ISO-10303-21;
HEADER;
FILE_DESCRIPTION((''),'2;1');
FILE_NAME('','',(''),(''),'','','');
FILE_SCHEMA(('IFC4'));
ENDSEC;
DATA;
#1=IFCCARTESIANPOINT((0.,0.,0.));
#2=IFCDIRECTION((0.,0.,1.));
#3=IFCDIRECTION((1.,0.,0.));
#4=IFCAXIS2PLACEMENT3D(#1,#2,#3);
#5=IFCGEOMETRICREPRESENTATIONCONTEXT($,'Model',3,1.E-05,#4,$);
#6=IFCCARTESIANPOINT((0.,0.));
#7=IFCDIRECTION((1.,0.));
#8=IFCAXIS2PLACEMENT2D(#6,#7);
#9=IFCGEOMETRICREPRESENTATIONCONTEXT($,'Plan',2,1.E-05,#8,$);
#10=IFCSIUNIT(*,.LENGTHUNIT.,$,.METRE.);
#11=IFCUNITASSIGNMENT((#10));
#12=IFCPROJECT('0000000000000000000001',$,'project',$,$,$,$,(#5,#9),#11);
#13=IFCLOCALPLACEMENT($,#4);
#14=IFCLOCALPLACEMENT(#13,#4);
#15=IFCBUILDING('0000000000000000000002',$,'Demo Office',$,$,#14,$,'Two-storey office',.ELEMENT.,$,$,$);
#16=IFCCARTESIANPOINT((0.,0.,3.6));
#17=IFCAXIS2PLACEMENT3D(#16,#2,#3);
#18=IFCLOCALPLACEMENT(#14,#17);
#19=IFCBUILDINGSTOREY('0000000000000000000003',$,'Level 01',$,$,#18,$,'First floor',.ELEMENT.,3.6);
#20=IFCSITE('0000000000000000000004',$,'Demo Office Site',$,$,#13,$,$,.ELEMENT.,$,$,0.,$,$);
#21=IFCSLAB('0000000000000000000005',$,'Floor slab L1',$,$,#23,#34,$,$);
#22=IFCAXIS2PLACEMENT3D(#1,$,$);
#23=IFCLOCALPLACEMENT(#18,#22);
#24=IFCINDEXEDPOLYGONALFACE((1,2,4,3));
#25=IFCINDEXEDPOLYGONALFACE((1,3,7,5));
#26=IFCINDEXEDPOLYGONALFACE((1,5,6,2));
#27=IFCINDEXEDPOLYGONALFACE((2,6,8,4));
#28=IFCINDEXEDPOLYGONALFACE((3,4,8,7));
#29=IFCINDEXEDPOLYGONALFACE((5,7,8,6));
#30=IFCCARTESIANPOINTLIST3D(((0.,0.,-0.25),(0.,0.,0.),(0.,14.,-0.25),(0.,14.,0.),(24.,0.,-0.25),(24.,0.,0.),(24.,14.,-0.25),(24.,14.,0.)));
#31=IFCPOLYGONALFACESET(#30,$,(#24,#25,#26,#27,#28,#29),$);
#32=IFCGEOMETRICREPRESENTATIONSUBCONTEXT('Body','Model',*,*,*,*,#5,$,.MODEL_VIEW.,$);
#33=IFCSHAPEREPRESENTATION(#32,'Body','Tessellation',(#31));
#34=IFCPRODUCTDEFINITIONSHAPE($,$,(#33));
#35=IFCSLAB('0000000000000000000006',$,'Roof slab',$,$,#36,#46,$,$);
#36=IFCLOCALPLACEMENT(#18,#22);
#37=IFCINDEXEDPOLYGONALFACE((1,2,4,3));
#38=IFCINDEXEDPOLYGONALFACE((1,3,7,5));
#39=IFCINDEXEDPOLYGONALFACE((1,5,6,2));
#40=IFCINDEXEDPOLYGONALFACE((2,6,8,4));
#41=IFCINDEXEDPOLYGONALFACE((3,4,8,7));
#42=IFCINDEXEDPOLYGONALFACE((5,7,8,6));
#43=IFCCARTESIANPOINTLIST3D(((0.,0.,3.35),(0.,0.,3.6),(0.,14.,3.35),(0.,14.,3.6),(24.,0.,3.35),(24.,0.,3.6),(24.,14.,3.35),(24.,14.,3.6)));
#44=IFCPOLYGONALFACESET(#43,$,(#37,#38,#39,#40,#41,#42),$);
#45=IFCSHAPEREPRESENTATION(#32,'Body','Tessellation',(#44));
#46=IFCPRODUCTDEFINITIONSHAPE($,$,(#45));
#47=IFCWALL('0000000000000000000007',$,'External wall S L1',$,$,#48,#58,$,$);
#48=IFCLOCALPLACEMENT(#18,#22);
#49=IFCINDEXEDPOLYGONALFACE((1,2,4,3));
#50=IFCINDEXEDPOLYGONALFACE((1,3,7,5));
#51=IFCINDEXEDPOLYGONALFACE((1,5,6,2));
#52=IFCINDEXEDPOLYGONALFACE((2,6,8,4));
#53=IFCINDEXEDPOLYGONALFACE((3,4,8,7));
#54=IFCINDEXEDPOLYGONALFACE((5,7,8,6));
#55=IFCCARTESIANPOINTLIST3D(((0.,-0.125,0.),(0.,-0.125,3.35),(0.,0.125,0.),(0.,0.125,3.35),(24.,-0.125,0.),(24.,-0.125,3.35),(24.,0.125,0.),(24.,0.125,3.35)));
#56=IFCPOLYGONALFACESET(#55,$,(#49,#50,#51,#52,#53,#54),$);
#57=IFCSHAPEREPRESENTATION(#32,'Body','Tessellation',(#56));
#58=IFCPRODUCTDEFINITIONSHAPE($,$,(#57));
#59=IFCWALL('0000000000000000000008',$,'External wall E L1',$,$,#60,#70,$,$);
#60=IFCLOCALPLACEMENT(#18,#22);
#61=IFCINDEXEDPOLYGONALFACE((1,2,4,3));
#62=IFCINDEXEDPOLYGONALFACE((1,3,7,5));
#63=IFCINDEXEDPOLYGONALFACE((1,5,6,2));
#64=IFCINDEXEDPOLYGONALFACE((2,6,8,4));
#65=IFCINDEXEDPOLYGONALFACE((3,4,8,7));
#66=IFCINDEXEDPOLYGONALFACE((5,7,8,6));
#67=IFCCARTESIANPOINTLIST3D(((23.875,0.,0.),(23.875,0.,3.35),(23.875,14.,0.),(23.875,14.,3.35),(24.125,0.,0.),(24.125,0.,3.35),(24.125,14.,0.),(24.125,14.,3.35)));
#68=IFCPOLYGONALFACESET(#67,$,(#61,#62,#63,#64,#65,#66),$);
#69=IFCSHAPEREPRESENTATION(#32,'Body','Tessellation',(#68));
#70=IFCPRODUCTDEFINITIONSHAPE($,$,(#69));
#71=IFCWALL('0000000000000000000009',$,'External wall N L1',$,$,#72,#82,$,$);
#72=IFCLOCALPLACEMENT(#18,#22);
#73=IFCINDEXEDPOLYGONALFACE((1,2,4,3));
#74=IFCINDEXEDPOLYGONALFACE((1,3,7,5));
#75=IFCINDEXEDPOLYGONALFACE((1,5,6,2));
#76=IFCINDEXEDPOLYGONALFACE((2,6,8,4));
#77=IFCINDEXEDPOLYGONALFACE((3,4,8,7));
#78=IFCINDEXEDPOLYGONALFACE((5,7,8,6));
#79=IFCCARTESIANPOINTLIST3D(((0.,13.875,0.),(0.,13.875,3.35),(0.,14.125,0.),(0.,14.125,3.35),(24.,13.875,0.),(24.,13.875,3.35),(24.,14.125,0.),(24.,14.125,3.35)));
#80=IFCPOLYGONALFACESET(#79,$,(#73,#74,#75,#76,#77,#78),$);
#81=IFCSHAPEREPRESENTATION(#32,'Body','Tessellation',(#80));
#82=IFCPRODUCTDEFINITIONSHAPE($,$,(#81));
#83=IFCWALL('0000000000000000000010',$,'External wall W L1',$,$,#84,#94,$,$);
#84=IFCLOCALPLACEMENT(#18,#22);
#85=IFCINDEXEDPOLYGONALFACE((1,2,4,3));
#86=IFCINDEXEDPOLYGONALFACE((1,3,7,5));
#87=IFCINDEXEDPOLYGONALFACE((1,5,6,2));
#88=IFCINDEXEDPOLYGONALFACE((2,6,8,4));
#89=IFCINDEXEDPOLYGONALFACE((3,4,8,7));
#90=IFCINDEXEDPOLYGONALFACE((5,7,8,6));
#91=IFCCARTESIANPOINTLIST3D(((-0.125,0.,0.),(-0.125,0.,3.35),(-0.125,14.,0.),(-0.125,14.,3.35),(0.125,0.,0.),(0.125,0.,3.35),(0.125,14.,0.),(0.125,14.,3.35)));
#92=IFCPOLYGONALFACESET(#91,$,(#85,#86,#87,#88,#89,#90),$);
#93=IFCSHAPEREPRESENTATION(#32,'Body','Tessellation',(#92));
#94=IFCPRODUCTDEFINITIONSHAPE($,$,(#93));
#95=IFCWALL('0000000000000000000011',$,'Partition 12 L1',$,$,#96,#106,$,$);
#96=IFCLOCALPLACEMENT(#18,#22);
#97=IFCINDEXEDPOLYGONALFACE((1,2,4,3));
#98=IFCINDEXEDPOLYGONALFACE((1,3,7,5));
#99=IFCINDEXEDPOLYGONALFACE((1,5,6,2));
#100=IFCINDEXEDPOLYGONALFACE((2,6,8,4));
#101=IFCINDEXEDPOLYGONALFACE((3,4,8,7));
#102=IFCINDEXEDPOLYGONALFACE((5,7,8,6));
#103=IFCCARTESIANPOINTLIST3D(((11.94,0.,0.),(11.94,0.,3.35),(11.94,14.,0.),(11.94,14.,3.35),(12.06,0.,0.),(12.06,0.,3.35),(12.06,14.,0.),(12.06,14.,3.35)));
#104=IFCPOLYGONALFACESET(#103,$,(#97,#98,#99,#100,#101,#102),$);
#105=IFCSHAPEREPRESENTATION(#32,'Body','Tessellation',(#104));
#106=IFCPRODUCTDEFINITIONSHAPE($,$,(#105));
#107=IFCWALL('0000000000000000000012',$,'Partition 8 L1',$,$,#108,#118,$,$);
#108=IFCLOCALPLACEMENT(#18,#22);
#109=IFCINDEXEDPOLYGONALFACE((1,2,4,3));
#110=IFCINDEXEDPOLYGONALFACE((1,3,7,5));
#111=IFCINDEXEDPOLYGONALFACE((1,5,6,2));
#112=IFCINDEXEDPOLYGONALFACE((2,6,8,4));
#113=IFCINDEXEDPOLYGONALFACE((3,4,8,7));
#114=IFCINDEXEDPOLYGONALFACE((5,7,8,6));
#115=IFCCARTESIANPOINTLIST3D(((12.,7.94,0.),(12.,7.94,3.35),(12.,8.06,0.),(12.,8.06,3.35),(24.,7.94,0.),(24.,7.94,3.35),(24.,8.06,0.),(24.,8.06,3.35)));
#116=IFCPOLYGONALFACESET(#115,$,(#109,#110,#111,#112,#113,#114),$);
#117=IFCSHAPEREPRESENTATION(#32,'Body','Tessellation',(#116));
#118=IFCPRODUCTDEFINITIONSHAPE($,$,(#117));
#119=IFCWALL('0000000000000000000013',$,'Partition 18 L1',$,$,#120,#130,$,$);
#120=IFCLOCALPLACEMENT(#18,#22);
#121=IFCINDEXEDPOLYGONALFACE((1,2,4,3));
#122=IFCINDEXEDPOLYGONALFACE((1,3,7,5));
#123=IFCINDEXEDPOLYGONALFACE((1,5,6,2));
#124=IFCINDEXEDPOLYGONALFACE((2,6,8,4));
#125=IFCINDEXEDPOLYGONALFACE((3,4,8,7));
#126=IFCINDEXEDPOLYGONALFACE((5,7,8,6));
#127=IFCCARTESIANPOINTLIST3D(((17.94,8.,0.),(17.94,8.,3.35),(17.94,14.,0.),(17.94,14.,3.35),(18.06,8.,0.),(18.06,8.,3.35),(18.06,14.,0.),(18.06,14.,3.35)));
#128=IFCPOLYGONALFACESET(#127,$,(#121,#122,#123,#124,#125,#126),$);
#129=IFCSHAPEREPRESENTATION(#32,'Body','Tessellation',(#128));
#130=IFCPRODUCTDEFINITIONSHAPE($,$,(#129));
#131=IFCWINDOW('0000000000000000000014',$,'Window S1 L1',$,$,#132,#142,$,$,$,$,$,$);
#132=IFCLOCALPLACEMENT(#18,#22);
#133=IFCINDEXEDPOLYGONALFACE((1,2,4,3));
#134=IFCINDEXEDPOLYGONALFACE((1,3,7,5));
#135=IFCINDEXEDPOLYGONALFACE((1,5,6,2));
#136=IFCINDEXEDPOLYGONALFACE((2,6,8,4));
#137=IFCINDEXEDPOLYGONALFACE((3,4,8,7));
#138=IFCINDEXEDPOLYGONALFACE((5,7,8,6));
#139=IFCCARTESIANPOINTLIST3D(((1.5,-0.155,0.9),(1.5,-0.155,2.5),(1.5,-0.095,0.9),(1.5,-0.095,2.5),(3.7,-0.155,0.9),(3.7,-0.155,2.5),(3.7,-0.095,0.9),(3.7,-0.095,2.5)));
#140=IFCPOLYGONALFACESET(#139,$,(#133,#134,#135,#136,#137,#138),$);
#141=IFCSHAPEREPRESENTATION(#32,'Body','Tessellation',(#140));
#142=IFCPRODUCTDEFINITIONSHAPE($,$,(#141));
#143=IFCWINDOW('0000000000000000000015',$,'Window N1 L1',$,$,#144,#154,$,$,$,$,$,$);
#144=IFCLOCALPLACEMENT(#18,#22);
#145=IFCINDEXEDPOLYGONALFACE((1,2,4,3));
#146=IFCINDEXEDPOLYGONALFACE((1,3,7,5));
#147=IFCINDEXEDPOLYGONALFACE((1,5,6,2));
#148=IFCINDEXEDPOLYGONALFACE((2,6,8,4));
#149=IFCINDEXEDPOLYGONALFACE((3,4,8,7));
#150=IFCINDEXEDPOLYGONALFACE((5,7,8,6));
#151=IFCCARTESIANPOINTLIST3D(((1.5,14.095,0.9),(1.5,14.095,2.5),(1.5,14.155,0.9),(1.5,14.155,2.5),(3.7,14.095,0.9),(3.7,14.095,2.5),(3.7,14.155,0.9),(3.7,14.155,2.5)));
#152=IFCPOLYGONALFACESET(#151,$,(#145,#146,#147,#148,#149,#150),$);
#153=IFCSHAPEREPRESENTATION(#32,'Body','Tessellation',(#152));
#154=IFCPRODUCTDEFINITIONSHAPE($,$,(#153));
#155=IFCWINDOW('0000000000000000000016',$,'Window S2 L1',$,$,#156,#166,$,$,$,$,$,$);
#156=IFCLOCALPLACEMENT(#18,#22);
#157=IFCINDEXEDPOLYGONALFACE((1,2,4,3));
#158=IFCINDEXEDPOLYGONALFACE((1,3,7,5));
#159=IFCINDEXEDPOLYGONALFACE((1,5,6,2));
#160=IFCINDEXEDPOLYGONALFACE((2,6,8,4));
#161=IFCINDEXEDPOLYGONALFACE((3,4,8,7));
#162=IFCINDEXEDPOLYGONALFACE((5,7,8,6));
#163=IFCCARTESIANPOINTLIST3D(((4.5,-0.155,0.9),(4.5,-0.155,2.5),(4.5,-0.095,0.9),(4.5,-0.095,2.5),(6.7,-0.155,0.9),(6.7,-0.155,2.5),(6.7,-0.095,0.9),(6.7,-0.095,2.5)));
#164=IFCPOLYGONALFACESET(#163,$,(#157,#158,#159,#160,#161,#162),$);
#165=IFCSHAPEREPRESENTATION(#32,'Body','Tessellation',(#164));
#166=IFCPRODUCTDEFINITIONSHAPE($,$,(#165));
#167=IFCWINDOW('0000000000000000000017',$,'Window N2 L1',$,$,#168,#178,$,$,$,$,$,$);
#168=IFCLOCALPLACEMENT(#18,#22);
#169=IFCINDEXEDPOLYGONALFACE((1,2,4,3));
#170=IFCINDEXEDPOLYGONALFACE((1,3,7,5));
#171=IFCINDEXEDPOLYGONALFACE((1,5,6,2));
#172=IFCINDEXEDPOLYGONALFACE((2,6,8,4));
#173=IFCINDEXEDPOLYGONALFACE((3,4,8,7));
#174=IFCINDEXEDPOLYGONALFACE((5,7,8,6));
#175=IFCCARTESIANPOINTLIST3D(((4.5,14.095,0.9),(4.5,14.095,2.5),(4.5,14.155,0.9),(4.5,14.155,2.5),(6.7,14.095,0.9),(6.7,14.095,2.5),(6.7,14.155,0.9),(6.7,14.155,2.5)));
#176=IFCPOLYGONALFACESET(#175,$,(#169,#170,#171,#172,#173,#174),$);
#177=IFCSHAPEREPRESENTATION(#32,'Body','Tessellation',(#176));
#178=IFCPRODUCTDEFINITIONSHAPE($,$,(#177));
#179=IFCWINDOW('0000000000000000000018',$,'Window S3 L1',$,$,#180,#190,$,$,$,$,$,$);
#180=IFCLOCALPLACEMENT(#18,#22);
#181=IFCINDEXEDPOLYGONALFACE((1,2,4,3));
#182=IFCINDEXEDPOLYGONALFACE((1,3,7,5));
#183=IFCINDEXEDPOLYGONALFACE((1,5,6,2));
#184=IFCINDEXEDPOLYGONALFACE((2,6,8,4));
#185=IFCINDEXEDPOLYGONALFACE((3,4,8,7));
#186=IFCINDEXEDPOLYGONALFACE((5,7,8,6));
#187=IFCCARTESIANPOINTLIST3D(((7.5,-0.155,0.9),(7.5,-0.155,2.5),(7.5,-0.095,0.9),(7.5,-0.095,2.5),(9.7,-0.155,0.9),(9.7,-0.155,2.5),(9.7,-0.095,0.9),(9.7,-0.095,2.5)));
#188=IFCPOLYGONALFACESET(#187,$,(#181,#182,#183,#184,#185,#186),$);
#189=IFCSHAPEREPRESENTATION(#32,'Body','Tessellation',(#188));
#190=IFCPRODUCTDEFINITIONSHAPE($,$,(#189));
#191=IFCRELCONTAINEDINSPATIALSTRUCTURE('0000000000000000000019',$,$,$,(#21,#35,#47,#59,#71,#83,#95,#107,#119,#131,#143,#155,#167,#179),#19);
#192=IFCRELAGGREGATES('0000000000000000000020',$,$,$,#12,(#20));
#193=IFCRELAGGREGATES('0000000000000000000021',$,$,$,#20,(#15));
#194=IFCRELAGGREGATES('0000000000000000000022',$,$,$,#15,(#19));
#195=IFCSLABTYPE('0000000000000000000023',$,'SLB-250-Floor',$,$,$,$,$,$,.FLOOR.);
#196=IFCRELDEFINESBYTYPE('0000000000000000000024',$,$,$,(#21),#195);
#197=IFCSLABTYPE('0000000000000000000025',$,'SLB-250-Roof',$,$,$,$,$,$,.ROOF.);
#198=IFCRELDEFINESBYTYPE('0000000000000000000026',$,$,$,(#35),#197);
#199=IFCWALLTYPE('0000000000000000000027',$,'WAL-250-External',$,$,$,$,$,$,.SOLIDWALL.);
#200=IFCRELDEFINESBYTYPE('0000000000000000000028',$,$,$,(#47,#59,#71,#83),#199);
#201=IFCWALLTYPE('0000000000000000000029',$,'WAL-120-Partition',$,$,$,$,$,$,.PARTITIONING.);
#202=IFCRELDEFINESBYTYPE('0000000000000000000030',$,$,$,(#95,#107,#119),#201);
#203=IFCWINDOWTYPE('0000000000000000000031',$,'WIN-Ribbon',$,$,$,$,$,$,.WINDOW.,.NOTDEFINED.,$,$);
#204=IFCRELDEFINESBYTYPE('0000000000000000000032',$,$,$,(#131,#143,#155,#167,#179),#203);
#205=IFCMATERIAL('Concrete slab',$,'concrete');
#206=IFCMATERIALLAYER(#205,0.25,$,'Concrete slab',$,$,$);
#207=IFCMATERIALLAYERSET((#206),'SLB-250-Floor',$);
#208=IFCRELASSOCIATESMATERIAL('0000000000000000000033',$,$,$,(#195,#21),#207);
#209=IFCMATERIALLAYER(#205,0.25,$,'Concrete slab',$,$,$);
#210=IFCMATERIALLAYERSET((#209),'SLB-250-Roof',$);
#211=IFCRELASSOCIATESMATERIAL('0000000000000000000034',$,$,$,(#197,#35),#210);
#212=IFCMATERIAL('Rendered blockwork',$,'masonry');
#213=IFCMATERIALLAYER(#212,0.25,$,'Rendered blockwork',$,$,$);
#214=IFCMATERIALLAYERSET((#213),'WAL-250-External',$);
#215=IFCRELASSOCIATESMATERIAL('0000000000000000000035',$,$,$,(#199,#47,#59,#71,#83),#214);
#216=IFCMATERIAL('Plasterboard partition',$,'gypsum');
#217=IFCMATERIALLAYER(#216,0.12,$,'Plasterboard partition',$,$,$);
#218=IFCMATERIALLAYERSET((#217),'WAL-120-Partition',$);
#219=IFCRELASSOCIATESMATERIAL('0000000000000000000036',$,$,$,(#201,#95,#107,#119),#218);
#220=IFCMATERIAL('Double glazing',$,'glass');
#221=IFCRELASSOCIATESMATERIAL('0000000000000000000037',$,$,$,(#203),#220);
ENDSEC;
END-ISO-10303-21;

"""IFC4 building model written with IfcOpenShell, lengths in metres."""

from ifc_helpers import new_model, si_unit, frame, origin_with_axes, origin_2d_with_axis, place, context, subcontext, project, spatial, line, indexed_curve, outline, extrude, material, layer, layer_set, layer_usage, type_object, element, save


model = new_model("IFC4")

# Units and contexts
model_context = context("Model", 3, precision=1e-05, world=origin_with_axes())
plan_context = context("Plan", 2, precision=1e-05, world=origin_2d_with_axis())
body_context = subcontext(model_context, "Body", "Model", "MODEL_VIEW")
ifc_project = project(units=[si_unit("LENGTHUNIT", "METRE")], contexts=[model_context, plan_context])

# Site, building, storey
site_placement = place(None, origin_with_axes())
site = spatial("IfcSite", under=ifc_project, at=site_placement, Name="Demo Office Site", CompositionType="ELEMENT", RefElevation=0.0)
building_placement = place(site_placement, origin_with_axes())
building = spatial("IfcBuilding", under=site, at=building_placement, Name="Demo Office", LongName="Two-storey office", CompositionType="ELEMENT")
storey_placement = place(building_placement, frame((0.0, 0.0, 3.6), z_axis=(0.0, 0.0, 1.0), x_axis=(1.0, 0.0, 0.0)))
storey = spatial("IfcBuildingStorey", under=building, at=storey_placement, Name="Level 01", LongName="First floor", CompositionType="ELEMENT", Elevation=3.6)

# Slabs
ifc_material_1 = material(Name="Concrete slab", Category="concrete")
ifc_layer_1 = layer(ifc_material_1, 0.25, Name="Concrete slab")
ifc_layer_set_1 = layer_set([ifc_layer_1], Name="SLB-250-Floor")
ifc_layer_usage_1 = layer_usage(ifc_layer_set_1, "AXIS3", "POSITIVE", 0.0)
slab_type_1 = type_object("IfcSlabType", Name="SLB-250-Floor", PredefinedType="FLOOR", material=ifc_layer_set_1)
slab_1_placement = place(storey_placement, frame((0.0, 0.0, -0.25), z_axis=(0.0, 0.0, 1.0), x_axis=(1.0, 0.0, 0.0)))
element("IfcSlab", 1, at=slab_1_placement, inside=storey, type_object=slab_type_1, material=ifc_layer_usage_1, Name="Floor slab L1", context=body_context, shape_type="SweptSolid", body=[
    extrude(outline(indexed_curve([(0.0, 0.0), (24.0, 0.0), (24.0, 14.0), (0.0, 14.0)], segments=[line(1, 2, 3, 4, 1)])), origin_with_axes(), (0.0, 0.0, 1.0), 0.25),
])
ifc_layer_2 = layer(ifc_material_1, 0.25, Name="Concrete slab")
ifc_layer_set_2 = layer_set([ifc_layer_2], Name="SLB-250-Roof")
ifc_layer_usage_2 = layer_usage(ifc_layer_set_2, "AXIS3", "POSITIVE", 0.0)
slab_type_2 = type_object("IfcSlabType", Name="SLB-250-Roof", PredefinedType="ROOF", material=ifc_layer_set_2)
slab_2_placement = place(storey_placement, frame((0.0, 0.0, 3.35), z_axis=(0.0, 0.0, 1.0), x_axis=(1.0, 0.0, 0.0)))
element("IfcSlab", 2, at=slab_2_placement, inside=storey, type_object=slab_type_2, material=ifc_layer_usage_2, Name="Roof slab", context=body_context, shape_type="SweptSolid", body=[
    extrude(outline(indexed_curve([(0.0, 0.0), (24.0, 0.0), (24.0, 14.0), (0.0, 14.0)], segments=[line(1, 2, 3, 4, 1)])), origin_with_axes(), (0.0, 0.0, 1.0), 0.25),
])

# Walls
ifc_material_2 = material(Name="Rendered blockwork", Category="masonry")
ifc_layer_3 = layer(ifc_material_2, 0.25, Name="Rendered blockwork")
ifc_layer_set_3 = layer_set([ifc_layer_3], Name="WAL-250-External")
ifc_layer_usage_3 = layer_usage(ifc_layer_set_3, "AXIS2", "POSITIVE", 0.0)
wall_type_1 = type_object("IfcWallType", Name="WAL-250-External", PredefinedType="SOLIDWALL", material=ifc_layer_set_3)
wall_1_placement = place(storey_placement, origin_with_axes())
element("IfcWall", 3, at=wall_1_placement, inside=storey, type_object=wall_type_1, material=ifc_layer_usage_3, Name="External wall S L1", context=body_context, shape_type="SweptSolid", body=[
    extrude(outline(indexed_curve([(0.0, 0.0), (0.0, 0.25), (24.0, 0.25), (24.0, 0.0), (0.0, 0.0)], self_intersect=False)), frame((0.0, -0.125, 0.0), z_axis=(0.0, 0.0, 1.0), x_axis=(1.0, 0.0, 0.0)), (0.0, 0.0, 1.0), 3.35),
])
ifc_layer_usage_4 = layer_usage(ifc_layer_set_3, "AXIS2", "POSITIVE", 0.0)
wall_2_placement = place(storey_placement, frame((24.0, 0.0, 0.0), z_axis=(0.0, 0.0, 1.0), x_axis=(0.0, 1.0, 0.0)))
element("IfcWall", 4, at=wall_2_placement, inside=storey, type_object=wall_type_1, material=ifc_layer_usage_4, Name="External wall E L1", context=body_context, shape_type="SweptSolid", body=[
    extrude(outline(indexed_curve([(0.0, 0.0), (0.0, 0.25), (14.0, 0.25), (14.0, 0.0), (0.0, 0.0)], self_intersect=False)), frame((0.0, -0.125, 0.0), z_axis=(0.0, 0.0, 1.0), x_axis=(1.0, 0.0, 0.0)), (0.0, 0.0, 1.0), 3.35),
])
ifc_layer_usage_5 = layer_usage(ifc_layer_set_3, "AXIS2", "POSITIVE", 0.0)
wall_3_placement = place(storey_placement, frame((24.0, 14.0, 0.0), z_axis=(0.0, 0.0, 1.0), x_axis=(-1.0, 0.0, 0.0)))
element("IfcWall", 5, at=wall_3_placement, inside=storey, type_object=wall_type_1, material=ifc_layer_usage_5, Name="External wall N L1", context=body_context, shape_type="SweptSolid", body=[
    extrude(outline(indexed_curve([(0.0, 0.0), (0.0, 0.25), (24.0, 0.25), (24.0, 0.0), (0.0, 0.0)], self_intersect=False)), frame((0.0, -0.125, 0.0), z_axis=(0.0, 0.0, 1.0), x_axis=(1.0, 0.0, 0.0)), (0.0, 0.0, 1.0), 3.35),
])
ifc_layer_usage_6 = layer_usage(ifc_layer_set_3, "AXIS2", "POSITIVE", 0.0)
wall_4_placement = place(storey_placement, frame((0.0, 14.0, 0.0), z_axis=(0.0, 0.0, 1.0), x_axis=(0.0, -1.0, 0.0)))
element("IfcWall", 6, at=wall_4_placement, inside=storey, type_object=wall_type_1, material=ifc_layer_usage_6, Name="External wall W L1", context=body_context, shape_type="SweptSolid", body=[
    extrude(outline(indexed_curve([(0.0, 0.0), (0.0, 0.25), (14.0, 0.25), (14.0, 0.0), (0.0, 0.0)], self_intersect=False)), frame((0.0, -0.125, 0.0), z_axis=(0.0, 0.0, 1.0), x_axis=(1.0, 0.0, 0.0)), (0.0, 0.0, 1.0), 3.35),
])
ifc_material_3 = material(Name="Plasterboard partition", Category="gypsum")
ifc_layer_4 = layer(ifc_material_3, 0.12, Name="Plasterboard partition")
ifc_layer_set_4 = layer_set([ifc_layer_4], Name="WAL-120-Partition")
ifc_layer_usage_7 = layer_usage(ifc_layer_set_4, "AXIS2", "POSITIVE", 0.0)
wall_type_2 = type_object("IfcWallType", Name="WAL-120-Partition", PredefinedType="PARTITIONING", material=ifc_layer_set_4)
wall_5_placement = place(storey_placement, frame((12.0, 0.0, 0.0), z_axis=(0.0, 0.0, 1.0), x_axis=(0.0, 1.0, 0.0)))
element("IfcWall", 7, at=wall_5_placement, inside=storey, type_object=wall_type_2, material=ifc_layer_usage_7, Name="Partition 12 L1", context=body_context, shape_type="SweptSolid", body=[
    extrude(outline(indexed_curve([(0.0, 0.0), (0.0, 0.12), (14.0, 0.12), (14.0, 0.0), (0.0, 0.0)], self_intersect=False)), frame((0.0, -0.06, 0.0), z_axis=(0.0, 0.0, 1.0), x_axis=(1.0, 0.0, 0.0)), (0.0, 0.0, 1.0), 3.35),
])
ifc_layer_usage_8 = layer_usage(ifc_layer_set_4, "AXIS2", "POSITIVE", 0.0)
wall_6_placement = place(storey_placement, frame((12.0, 8.0, 0.0), z_axis=(0.0, 0.0, 1.0), x_axis=(1.0, 0.0, 0.0)))
element("IfcWall", 8, at=wall_6_placement, inside=storey, type_object=wall_type_2, material=ifc_layer_usage_8, Name="Partition 8 L1", context=body_context, shape_type="SweptSolid", body=[
    extrude(outline(indexed_curve([(0.0, 0.0), (0.0, 0.12), (12.0, 0.12), (12.0, 0.0), (0.0, 0.0)], self_intersect=False)), frame((0.0, -0.06, 0.0), z_axis=(0.0, 0.0, 1.0), x_axis=(1.0, 0.0, 0.0)), (0.0, 0.0, 1.0), 3.35),
])
ifc_layer_usage_9 = layer_usage(ifc_layer_set_4, "AXIS2", "POSITIVE", 0.0)
wall_7_placement = place(storey_placement, frame((18.0, 8.0, 0.0), z_axis=(0.0, 0.0, 1.0), x_axis=(0.0, 1.0, 0.0)))
element("IfcWall", 9, at=wall_7_placement, inside=storey, type_object=wall_type_2, material=ifc_layer_usage_9, Name="Partition 18 L1", context=body_context, shape_type="SweptSolid", body=[
    extrude(outline(indexed_curve([(0.0, 0.0), (0.0, 0.12), (6.0, 0.12), (6.0, 0.0), (0.0, 0.0)], self_intersect=False)), frame((0.0, -0.06, 0.0), z_axis=(0.0, 0.0, 1.0), x_axis=(1.0, 0.0, 0.0)), (0.0, 0.0, 1.0), 3.35),
])

# Windows
ifc_material_4 = material(Name="Double glazing", Category="glass")
window_type = type_object("IfcWindowType", Name="WIN-Ribbon", PartitioningType="NOTDEFINED", PredefinedType="WINDOW", material=ifc_material_4)
for number, where, z_axis, x_axis, name in (
    (10, (1.5, -0.155, 0.9), (0.0, 0.0, 1.0), (1.0, 0.0, 0.0), "Window S1 L1"),
    (11, (1.5, 14.095, 0.9), (0.0, 0.0, 1.0), (1.0, 0.0, 0.0), "Window N1 L1"),
    (12, (4.5, -0.155, 0.9), (0.0, 0.0, 1.0), (1.0, 0.0, 0.0), "Window S2 L1"),
    (13, (4.5, 14.095, 0.9), (0.0, 0.0, 1.0), (1.0, 0.0, 0.0), "Window N2 L1"),
    (14, (7.5, -0.155, 0.9), (0.0, 0.0, 1.0), (1.0, 0.0, 0.0), "Window S3 L1"),
):
    element("IfcWindow", number, at=place(storey_placement, frame(where, z_axis=z_axis, x_axis=x_axis)), inside=storey, type_object=window_type, Name=name, context=body_context, shape_type="SweptSolid", body=[
        extrude(outline(indexed_curve([(0.0, 0.0), (2.2, 0.0), (2.2, 0.06), (0.0, 0.06)], segments=[line(1, 2, 3, 4, 1)])), origin_with_axes(), (0.0, 0.0, 1.0), 1.6),
    ])

save(model, "model.ifc")
